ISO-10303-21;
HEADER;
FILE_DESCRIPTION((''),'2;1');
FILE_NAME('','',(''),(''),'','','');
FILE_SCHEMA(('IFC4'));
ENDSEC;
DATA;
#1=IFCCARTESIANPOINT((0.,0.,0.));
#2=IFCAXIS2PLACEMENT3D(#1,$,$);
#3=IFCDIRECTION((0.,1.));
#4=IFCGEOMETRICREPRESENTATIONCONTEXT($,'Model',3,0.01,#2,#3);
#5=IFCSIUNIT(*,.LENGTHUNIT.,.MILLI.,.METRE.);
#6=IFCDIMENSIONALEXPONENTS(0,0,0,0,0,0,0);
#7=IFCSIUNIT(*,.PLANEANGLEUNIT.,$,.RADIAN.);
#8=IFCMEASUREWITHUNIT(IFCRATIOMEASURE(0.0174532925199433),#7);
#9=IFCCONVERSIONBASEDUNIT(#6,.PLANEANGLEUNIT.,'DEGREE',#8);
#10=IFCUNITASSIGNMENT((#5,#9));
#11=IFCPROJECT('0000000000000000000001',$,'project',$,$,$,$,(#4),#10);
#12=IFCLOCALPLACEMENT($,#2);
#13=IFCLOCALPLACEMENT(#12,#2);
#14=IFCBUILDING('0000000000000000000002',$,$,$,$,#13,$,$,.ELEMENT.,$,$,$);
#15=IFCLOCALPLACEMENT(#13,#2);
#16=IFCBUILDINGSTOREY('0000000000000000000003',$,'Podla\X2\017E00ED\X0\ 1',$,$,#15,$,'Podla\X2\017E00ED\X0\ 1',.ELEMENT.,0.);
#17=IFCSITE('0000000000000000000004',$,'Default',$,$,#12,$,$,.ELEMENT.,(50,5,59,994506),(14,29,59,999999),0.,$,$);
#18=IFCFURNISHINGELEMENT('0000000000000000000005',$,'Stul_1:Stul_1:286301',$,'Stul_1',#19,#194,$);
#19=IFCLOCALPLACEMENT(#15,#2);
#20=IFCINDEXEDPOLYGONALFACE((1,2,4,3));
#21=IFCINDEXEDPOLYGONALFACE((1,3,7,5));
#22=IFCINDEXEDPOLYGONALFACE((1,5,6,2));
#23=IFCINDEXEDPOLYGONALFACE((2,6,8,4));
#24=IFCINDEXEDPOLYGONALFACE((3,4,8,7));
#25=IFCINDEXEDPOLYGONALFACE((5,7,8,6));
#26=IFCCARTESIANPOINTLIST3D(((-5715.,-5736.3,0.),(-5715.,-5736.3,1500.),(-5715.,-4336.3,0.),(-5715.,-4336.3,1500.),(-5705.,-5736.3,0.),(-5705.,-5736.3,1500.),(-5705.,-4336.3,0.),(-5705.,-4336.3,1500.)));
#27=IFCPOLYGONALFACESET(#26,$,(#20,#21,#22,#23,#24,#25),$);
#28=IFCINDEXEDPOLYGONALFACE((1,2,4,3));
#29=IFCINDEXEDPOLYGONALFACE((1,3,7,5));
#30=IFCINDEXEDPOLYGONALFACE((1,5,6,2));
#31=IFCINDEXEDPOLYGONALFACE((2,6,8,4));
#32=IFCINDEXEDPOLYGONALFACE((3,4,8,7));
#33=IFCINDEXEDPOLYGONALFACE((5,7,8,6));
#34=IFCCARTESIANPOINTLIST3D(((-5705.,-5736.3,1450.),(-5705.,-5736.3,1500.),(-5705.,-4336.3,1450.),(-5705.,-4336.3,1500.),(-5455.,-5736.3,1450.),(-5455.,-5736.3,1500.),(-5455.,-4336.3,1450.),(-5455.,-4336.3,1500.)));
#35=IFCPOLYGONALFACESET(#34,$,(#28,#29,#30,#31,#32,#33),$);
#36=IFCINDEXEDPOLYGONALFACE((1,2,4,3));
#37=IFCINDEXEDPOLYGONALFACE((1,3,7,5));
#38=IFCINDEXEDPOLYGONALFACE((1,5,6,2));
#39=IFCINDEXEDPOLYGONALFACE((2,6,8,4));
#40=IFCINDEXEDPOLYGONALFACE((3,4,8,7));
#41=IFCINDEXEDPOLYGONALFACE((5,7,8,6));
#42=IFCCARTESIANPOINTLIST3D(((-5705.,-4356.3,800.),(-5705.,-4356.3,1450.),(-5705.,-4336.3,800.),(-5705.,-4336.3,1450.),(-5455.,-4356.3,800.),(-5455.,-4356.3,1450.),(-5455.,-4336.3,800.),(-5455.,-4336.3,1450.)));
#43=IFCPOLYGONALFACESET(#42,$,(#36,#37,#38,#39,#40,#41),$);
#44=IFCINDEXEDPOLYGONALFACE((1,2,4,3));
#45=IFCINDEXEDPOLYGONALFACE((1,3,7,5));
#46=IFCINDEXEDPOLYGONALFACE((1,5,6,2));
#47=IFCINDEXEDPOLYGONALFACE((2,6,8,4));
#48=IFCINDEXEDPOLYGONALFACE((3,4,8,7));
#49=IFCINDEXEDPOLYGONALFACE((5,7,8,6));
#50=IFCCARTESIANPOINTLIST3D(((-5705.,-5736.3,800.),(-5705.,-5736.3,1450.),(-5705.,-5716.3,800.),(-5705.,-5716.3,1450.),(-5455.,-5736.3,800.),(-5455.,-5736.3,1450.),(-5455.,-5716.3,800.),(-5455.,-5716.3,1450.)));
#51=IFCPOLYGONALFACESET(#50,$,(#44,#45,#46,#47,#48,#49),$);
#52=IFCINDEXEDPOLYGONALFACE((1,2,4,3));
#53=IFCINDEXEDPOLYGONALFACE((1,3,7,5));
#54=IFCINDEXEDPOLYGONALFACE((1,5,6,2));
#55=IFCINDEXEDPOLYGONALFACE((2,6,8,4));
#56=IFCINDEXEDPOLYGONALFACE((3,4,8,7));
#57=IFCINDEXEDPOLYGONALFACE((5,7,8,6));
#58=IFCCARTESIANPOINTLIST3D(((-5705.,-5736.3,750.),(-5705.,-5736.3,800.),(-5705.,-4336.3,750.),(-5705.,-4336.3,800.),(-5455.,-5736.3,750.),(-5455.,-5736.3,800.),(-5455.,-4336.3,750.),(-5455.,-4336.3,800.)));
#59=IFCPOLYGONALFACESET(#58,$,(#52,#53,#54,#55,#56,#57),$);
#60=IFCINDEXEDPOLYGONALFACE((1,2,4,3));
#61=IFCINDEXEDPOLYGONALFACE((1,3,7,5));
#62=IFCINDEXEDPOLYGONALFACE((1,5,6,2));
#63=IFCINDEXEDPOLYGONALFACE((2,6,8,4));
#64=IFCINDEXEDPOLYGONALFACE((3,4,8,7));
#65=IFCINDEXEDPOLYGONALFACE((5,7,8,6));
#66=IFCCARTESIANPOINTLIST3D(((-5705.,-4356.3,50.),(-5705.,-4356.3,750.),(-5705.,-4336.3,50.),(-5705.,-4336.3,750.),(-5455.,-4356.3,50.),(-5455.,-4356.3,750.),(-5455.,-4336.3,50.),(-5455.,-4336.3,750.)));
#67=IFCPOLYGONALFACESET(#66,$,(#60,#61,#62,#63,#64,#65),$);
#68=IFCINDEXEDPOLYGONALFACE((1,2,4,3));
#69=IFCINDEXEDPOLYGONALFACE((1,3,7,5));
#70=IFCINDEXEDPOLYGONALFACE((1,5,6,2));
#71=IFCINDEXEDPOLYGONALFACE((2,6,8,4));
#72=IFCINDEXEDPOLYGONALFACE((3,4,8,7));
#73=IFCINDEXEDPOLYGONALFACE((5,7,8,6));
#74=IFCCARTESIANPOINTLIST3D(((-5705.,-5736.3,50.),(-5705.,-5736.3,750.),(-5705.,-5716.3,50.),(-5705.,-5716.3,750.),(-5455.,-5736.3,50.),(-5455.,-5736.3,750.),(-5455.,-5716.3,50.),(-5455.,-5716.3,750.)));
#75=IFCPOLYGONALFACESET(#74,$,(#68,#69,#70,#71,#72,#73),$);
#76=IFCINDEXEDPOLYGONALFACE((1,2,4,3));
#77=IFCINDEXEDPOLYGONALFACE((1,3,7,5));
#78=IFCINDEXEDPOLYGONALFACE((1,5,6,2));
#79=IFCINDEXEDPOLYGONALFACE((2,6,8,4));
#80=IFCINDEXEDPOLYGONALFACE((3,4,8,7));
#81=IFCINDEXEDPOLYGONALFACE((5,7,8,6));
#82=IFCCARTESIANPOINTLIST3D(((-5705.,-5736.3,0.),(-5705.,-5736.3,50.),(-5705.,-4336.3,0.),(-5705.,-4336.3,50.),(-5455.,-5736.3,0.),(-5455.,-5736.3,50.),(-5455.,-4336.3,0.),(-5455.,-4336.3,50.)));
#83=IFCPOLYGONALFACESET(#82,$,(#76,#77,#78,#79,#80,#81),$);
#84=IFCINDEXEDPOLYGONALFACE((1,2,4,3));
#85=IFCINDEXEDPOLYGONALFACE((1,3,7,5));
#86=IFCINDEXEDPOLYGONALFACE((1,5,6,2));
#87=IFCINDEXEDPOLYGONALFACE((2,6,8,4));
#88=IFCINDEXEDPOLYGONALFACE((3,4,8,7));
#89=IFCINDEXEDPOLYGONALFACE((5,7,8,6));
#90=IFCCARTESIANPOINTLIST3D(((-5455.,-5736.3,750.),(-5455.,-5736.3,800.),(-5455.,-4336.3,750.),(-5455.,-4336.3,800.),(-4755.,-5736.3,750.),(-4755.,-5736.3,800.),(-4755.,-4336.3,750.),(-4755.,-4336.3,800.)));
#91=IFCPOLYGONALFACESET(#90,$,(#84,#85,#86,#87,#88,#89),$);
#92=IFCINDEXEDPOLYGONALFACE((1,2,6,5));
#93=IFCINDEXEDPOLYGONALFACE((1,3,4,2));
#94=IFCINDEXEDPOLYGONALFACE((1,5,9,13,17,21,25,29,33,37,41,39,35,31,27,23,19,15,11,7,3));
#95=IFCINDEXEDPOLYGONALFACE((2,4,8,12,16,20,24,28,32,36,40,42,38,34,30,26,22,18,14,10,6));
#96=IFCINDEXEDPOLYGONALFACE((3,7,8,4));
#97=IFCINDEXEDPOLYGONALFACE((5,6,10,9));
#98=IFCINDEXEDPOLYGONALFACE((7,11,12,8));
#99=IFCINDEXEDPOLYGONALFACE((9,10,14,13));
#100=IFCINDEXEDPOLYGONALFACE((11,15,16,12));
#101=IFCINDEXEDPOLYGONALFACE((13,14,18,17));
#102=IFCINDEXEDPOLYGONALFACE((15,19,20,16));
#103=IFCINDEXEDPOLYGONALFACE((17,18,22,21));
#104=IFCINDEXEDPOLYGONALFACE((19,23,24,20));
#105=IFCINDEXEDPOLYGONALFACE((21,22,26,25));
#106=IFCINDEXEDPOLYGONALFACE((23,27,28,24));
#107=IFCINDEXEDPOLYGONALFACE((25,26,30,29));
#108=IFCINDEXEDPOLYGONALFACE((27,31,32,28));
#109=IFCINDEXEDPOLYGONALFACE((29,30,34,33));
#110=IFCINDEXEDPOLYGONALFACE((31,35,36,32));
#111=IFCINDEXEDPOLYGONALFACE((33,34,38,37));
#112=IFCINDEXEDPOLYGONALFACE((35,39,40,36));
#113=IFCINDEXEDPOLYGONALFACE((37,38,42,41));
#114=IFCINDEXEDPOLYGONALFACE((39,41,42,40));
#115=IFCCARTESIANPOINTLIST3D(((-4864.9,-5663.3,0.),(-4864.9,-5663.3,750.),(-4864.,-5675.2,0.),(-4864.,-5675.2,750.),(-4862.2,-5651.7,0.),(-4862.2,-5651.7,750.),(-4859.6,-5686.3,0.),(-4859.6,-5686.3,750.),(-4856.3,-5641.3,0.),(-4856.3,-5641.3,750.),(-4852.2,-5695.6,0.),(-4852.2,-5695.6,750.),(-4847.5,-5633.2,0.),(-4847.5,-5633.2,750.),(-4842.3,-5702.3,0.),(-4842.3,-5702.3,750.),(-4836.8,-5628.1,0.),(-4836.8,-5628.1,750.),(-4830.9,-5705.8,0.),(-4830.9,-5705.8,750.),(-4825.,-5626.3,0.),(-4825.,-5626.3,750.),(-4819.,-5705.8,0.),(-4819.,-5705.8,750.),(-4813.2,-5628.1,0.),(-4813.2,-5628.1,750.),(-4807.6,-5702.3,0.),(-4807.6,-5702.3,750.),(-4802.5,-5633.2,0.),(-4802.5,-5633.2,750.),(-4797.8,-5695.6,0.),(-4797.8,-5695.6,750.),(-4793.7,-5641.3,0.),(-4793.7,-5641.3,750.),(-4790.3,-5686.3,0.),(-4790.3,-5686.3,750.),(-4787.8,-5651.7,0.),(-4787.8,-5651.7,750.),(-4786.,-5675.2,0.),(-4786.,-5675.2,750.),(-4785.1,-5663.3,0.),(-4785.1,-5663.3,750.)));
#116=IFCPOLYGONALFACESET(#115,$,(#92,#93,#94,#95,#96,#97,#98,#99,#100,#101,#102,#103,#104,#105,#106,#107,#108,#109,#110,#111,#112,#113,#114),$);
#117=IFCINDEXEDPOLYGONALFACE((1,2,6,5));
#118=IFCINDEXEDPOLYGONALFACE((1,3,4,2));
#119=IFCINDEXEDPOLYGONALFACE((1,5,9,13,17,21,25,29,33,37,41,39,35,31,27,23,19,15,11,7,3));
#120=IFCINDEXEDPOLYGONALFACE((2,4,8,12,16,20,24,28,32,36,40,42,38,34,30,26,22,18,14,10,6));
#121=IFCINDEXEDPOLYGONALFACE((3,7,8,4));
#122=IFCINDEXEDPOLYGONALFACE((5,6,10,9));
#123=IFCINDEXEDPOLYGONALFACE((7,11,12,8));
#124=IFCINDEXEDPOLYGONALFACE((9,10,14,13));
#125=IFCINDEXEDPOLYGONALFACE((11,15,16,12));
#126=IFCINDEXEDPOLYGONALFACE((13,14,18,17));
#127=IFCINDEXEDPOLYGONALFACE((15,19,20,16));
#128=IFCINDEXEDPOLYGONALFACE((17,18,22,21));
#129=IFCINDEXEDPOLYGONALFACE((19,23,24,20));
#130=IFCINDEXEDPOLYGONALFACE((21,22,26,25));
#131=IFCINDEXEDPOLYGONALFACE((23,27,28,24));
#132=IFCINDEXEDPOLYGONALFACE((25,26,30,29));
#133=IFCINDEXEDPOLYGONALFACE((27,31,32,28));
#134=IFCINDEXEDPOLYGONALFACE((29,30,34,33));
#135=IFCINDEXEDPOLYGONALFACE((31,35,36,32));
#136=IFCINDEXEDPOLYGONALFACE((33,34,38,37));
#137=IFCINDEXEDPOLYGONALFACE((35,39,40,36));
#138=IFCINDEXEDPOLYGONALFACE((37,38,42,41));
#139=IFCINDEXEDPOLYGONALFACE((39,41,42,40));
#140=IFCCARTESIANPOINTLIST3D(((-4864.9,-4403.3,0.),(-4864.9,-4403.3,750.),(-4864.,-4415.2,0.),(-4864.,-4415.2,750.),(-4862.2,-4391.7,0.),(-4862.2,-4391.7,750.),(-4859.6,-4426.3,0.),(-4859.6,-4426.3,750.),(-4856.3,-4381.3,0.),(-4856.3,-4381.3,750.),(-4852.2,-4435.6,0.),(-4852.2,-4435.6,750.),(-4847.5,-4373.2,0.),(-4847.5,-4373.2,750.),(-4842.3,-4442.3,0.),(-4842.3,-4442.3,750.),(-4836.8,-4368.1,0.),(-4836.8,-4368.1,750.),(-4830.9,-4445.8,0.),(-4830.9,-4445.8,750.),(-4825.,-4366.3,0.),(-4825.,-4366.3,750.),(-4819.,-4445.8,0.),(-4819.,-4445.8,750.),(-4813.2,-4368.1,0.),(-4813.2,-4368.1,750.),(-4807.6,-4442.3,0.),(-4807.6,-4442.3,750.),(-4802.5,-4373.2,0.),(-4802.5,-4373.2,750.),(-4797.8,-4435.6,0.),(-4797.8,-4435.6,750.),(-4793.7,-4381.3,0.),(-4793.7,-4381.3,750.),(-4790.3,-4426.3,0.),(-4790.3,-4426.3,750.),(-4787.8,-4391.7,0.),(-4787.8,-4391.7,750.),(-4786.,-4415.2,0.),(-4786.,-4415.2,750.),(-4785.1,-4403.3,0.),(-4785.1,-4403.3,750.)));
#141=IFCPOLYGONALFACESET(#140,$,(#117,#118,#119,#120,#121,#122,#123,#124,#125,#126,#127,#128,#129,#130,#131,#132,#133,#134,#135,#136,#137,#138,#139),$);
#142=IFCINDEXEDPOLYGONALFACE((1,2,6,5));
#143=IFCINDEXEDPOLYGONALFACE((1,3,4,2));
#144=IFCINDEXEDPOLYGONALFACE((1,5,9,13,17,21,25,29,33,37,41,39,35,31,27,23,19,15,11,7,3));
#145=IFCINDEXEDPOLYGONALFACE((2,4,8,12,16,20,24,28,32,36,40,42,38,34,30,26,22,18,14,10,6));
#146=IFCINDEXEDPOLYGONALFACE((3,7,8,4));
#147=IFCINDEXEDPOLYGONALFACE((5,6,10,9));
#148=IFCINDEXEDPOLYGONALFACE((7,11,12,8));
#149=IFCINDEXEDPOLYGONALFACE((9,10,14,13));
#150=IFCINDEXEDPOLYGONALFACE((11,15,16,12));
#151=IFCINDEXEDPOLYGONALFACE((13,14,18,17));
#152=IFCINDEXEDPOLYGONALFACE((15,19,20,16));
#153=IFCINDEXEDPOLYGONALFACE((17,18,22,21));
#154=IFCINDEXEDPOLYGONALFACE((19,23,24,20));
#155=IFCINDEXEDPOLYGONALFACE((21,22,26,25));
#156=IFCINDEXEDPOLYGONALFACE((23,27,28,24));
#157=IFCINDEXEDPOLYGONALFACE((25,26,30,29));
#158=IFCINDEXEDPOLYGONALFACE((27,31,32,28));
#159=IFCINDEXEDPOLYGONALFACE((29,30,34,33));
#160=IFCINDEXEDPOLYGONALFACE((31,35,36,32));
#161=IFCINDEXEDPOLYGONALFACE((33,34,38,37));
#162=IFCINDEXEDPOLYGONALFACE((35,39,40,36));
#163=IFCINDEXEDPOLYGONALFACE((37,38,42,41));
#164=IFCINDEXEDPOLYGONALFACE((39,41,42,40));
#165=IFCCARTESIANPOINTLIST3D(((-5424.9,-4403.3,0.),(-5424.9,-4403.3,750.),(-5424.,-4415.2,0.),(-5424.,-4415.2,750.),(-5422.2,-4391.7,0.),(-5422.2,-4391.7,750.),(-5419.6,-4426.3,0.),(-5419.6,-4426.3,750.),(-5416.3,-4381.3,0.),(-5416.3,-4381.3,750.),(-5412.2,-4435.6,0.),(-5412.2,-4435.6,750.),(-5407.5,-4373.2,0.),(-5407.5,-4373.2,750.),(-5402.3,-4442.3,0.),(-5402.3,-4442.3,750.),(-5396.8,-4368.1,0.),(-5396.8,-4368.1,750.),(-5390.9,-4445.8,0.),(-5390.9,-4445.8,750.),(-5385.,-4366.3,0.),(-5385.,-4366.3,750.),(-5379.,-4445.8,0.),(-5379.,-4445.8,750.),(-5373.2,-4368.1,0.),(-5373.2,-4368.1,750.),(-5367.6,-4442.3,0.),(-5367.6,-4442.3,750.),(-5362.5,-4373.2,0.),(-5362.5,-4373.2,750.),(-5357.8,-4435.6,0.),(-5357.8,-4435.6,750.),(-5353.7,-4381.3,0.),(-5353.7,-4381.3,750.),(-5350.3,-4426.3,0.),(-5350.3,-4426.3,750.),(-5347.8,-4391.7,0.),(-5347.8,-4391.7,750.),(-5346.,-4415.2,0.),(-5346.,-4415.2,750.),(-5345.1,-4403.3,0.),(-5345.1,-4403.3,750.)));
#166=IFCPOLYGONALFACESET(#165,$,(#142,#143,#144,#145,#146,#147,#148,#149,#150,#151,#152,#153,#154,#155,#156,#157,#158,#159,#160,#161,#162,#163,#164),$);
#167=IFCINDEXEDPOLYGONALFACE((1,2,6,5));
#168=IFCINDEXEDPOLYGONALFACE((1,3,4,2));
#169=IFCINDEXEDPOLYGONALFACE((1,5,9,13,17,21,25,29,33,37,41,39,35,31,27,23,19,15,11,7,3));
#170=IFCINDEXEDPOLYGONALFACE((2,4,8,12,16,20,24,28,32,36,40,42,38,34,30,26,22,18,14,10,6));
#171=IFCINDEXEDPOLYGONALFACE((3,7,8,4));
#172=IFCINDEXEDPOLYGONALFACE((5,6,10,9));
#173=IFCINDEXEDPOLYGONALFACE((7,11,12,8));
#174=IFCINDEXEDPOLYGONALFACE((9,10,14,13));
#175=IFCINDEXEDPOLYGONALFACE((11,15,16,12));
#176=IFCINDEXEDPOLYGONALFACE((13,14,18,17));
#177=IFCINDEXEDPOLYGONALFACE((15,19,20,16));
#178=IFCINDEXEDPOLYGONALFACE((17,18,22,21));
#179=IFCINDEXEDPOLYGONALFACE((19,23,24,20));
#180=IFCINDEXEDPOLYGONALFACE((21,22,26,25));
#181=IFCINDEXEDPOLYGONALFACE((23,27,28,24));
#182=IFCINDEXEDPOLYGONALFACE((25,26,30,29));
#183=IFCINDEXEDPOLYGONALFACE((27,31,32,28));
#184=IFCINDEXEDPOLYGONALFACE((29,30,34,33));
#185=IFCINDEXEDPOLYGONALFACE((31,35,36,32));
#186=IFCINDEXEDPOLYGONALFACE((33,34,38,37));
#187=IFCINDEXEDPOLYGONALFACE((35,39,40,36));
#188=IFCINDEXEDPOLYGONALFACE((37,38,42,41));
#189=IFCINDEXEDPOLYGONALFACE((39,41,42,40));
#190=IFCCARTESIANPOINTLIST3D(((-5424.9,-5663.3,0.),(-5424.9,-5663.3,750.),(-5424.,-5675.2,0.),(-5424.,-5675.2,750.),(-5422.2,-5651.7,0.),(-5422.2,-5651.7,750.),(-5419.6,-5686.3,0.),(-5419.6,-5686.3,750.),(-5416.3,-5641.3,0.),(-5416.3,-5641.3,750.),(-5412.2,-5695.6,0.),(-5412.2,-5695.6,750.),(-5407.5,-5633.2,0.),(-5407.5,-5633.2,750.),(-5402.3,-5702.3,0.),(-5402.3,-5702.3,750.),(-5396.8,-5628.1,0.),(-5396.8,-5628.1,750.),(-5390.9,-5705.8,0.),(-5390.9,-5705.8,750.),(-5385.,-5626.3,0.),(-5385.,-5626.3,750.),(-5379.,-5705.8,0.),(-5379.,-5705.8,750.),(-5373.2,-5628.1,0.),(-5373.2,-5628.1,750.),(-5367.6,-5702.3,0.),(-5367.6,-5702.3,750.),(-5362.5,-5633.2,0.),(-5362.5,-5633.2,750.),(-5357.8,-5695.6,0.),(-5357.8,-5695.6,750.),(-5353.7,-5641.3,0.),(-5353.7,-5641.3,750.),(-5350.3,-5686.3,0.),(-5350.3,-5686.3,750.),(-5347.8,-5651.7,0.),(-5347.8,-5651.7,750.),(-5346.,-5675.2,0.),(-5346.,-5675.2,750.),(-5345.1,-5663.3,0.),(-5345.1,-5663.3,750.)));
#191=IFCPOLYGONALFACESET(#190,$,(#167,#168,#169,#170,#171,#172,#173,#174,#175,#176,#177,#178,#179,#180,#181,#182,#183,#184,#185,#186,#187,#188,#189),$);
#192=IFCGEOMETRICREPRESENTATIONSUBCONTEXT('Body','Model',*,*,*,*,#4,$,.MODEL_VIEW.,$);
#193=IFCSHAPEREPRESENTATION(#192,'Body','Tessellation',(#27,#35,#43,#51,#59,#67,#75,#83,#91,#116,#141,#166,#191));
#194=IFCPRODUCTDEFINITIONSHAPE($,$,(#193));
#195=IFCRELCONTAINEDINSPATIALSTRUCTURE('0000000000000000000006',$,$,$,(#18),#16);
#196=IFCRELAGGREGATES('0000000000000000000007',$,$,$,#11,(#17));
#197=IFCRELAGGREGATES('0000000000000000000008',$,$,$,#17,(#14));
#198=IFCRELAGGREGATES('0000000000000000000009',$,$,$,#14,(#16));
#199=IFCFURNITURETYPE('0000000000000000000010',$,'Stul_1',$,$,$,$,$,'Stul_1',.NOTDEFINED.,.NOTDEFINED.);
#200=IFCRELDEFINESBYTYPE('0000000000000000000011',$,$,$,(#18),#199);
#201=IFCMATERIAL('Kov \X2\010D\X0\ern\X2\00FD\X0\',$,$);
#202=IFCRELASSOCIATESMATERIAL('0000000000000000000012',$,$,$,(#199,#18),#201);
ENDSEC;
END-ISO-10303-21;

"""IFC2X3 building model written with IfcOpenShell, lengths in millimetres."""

from ifc_helpers import new_model, entity, si_unit, converted_unit, direction, frame, frame_2d, origin, origin_2d_with_axis, place, context, subcontext, project, spatial, rectangle, circle, extrude, source, transform, mapped, material, type_object, type_shapes, element, save


model = new_model("IFC2X3")

# Units and contexts
model_context = context("Model", 3, precision=0.01, world=origin(), true_north=direction((0.0, 1.0)))
body_context = subcontext(model_context, "Body", "Model", "MODEL_VIEW")
ifc_project = project(units=[si_unit("LENGTHUNIT", "METRE", prefix="MILLI"), converted_unit("PLANEANGLEUNIT", "DEGREE", entity("IfcRatioMeasure", 0.0174532925199433), si_unit("PLANEANGLEUNIT", "RADIAN"), dimensions=[0, 0, 0, 0, 0, 0, 0])], contexts=[model_context])

# Site, building, storey
site_placement = place(None, origin())
site = spatial("IfcSite", under=ifc_project, at=site_placement, Name="Default", CompositionType="ELEMENT", RefLatitude=(50, 5, 59, 994506), RefLongitude=(14, 29, 59, 999999), RefElevation=0.0)
building_placement = place(site_placement, origin())
building = spatial("IfcBuilding", under=site, at=building_placement, CompositionType="ELEMENT")
storey_placement = place(building_placement, origin())
storey = spatial("IfcBuildingStorey", under=building, at=storey_placement, Name="Podlaží 1", LongName="Podlaží 1", CompositionType="ELEMENT", Elevation=0.0)

# Furnishing element
ifc_material_1 = material(Name="Kov černý")
furniture_type = type_object("IfcFurnitureType", Name="Stul_1", ElementType="Stul_1", material=ifc_material_1)
shared_shape_1 = source(origin(), body_context, "Body", "SweptSolid", [
    extrude(rectangle(XDim=1400.0, YDim=10.0, at=origin_2d_with_axis()), frame((0.0, 605.0, 0.0), z_axis=(0.0, 0.0, 1.0), x_axis=(-1.0, 0.0, 0.0)), (0.0, 0.0, 1.0), 1500.0),
    extrude(rectangle(XDim=1400.0, YDim=250.0, at=frame_2d((0.0, 0.0), x_axis=(1.0, 0.0))), frame((0.0, 475.0, 1450.0), z_axis=(0.0, 0.0, 1.0), x_axis=(-1.0, 0.0, 0.0)), (0.0, 0.0, 1.0), 50.0),
    extrude(rectangle(XDim=20.0, YDim=250.0, at=origin_2d_with_axis()), frame((690.0, 475.0, 800.0), z_axis=(0.0, 0.0, 1.0), x_axis=(-1.0, 0.0, 0.0)), (0.0, 0.0, 1.0), 650.0),
    extrude(rectangle(XDim=20.0, YDim=250.0, at=frame_2d((0.0, 0.0), x_axis=(1.0, 0.0))), frame((-690.0, 475.0, 800.0), z_axis=(0.0, 0.0, 1.0), x_axis=(-1.0, 0.0, 0.0)), (0.0, 0.0, 1.0), 650.0),
    extrude(rectangle(XDim=1400.0, YDim=250.0, at=origin_2d_with_axis()), frame((0.0, 475.0, 750.0), z_axis=(0.0, 0.0, 1.0), x_axis=(-1.0, 0.0, 0.0)), (0.0, 0.0, 1.0), 50.0),
    extrude(rectangle(XDim=20.0, YDim=250.0, at=origin_2d_with_axis()), frame((690.0, 475.0, 50.0), z_axis=(0.0, 0.0, 1.0), x_axis=(-1.0, 0.0, 0.0)), (0.0, 0.0, 1.0), 700.0),
    extrude(rectangle(XDim=20.0, YDim=250.0, at=frame_2d((0.0, 0.0), x_axis=(1.0, 0.0))), frame((-690.0, 475.0, 50.0), z_axis=(0.0, 0.0, 1.0), x_axis=(-1.0, 0.0, 0.0)), (0.0, 0.0, 1.0), 700.0),
    extrude(rectangle(XDim=1400.0, YDim=250.0, at=origin_2d_with_axis()), frame((0.0, 475.0, 0.0), z_axis=(0.0, 0.0, 1.0), x_axis=(-1.0, 0.0, 0.0)), (0.0, 0.0, 1.0), 50.0),
    extrude(rectangle(XDim=1400.0, YDim=700.0, at=origin_2d_with_axis()), frame((0.0, 0.0, 750.0), z_axis=(0.0, 0.0, 1.0), x_axis=(-1.0, 0.0, 0.0)), (0.0, 0.0, 1.0), 50.0),
    extrude(circle(Radius=40.0, at=frame_2d((0.0, 0.0), x_axis=(1.0, 0.0))), frame((-630.0, -280.0, 0.0)), (0.0, 0.0, 1.0), 750.0),
    extrude(circle(Radius=40.0, at=frame_2d((0.0, 0.0), x_axis=(1.0, 0.0))), frame((630.0, -280.0, 0.0)), (0.0, 0.0, 1.0), 750.0),
    extrude(circle(Radius=40.0, at=frame_2d((0.0, 0.0), x_axis=(1.0, 0.0))), frame((630.0, 280.0, 0.0)), (0.0, 0.0, 1.0), 750.0),
    extrude(circle(Radius=40.0, at=frame_2d((0.0, 0.0), x_axis=(1.0, 0.0))), frame((-630.0, 280.0, 0.0)), (0.0, 0.0, 1.0), 750.0),
])
type_shapes(furniture_type, [shared_shape_1])
for number, where, z_axis, x_axis, name in (
    (1, (-5105.0, -5036.3, 0.0), (0.0, 0.0, 1.0), (0.0, 1.0, 0.0), "Stul_1:Stul_1:286301"),
):
    element("IfcFurnishingElement", number, at=place(storey_placement, frame(where, z_axis=z_axis, x_axis=x_axis)), inside=storey, type_object=furniture_type, material=ifc_material_1, Name=name, ObjectType="Stul_1", context=body_context, shape_type="MappedRepresentation", body=[
        mapped(shared_shape_1, transform((0.0, 0.0, 0.0), scale=1.0)),
    ])

save(model, "model.ifc")
